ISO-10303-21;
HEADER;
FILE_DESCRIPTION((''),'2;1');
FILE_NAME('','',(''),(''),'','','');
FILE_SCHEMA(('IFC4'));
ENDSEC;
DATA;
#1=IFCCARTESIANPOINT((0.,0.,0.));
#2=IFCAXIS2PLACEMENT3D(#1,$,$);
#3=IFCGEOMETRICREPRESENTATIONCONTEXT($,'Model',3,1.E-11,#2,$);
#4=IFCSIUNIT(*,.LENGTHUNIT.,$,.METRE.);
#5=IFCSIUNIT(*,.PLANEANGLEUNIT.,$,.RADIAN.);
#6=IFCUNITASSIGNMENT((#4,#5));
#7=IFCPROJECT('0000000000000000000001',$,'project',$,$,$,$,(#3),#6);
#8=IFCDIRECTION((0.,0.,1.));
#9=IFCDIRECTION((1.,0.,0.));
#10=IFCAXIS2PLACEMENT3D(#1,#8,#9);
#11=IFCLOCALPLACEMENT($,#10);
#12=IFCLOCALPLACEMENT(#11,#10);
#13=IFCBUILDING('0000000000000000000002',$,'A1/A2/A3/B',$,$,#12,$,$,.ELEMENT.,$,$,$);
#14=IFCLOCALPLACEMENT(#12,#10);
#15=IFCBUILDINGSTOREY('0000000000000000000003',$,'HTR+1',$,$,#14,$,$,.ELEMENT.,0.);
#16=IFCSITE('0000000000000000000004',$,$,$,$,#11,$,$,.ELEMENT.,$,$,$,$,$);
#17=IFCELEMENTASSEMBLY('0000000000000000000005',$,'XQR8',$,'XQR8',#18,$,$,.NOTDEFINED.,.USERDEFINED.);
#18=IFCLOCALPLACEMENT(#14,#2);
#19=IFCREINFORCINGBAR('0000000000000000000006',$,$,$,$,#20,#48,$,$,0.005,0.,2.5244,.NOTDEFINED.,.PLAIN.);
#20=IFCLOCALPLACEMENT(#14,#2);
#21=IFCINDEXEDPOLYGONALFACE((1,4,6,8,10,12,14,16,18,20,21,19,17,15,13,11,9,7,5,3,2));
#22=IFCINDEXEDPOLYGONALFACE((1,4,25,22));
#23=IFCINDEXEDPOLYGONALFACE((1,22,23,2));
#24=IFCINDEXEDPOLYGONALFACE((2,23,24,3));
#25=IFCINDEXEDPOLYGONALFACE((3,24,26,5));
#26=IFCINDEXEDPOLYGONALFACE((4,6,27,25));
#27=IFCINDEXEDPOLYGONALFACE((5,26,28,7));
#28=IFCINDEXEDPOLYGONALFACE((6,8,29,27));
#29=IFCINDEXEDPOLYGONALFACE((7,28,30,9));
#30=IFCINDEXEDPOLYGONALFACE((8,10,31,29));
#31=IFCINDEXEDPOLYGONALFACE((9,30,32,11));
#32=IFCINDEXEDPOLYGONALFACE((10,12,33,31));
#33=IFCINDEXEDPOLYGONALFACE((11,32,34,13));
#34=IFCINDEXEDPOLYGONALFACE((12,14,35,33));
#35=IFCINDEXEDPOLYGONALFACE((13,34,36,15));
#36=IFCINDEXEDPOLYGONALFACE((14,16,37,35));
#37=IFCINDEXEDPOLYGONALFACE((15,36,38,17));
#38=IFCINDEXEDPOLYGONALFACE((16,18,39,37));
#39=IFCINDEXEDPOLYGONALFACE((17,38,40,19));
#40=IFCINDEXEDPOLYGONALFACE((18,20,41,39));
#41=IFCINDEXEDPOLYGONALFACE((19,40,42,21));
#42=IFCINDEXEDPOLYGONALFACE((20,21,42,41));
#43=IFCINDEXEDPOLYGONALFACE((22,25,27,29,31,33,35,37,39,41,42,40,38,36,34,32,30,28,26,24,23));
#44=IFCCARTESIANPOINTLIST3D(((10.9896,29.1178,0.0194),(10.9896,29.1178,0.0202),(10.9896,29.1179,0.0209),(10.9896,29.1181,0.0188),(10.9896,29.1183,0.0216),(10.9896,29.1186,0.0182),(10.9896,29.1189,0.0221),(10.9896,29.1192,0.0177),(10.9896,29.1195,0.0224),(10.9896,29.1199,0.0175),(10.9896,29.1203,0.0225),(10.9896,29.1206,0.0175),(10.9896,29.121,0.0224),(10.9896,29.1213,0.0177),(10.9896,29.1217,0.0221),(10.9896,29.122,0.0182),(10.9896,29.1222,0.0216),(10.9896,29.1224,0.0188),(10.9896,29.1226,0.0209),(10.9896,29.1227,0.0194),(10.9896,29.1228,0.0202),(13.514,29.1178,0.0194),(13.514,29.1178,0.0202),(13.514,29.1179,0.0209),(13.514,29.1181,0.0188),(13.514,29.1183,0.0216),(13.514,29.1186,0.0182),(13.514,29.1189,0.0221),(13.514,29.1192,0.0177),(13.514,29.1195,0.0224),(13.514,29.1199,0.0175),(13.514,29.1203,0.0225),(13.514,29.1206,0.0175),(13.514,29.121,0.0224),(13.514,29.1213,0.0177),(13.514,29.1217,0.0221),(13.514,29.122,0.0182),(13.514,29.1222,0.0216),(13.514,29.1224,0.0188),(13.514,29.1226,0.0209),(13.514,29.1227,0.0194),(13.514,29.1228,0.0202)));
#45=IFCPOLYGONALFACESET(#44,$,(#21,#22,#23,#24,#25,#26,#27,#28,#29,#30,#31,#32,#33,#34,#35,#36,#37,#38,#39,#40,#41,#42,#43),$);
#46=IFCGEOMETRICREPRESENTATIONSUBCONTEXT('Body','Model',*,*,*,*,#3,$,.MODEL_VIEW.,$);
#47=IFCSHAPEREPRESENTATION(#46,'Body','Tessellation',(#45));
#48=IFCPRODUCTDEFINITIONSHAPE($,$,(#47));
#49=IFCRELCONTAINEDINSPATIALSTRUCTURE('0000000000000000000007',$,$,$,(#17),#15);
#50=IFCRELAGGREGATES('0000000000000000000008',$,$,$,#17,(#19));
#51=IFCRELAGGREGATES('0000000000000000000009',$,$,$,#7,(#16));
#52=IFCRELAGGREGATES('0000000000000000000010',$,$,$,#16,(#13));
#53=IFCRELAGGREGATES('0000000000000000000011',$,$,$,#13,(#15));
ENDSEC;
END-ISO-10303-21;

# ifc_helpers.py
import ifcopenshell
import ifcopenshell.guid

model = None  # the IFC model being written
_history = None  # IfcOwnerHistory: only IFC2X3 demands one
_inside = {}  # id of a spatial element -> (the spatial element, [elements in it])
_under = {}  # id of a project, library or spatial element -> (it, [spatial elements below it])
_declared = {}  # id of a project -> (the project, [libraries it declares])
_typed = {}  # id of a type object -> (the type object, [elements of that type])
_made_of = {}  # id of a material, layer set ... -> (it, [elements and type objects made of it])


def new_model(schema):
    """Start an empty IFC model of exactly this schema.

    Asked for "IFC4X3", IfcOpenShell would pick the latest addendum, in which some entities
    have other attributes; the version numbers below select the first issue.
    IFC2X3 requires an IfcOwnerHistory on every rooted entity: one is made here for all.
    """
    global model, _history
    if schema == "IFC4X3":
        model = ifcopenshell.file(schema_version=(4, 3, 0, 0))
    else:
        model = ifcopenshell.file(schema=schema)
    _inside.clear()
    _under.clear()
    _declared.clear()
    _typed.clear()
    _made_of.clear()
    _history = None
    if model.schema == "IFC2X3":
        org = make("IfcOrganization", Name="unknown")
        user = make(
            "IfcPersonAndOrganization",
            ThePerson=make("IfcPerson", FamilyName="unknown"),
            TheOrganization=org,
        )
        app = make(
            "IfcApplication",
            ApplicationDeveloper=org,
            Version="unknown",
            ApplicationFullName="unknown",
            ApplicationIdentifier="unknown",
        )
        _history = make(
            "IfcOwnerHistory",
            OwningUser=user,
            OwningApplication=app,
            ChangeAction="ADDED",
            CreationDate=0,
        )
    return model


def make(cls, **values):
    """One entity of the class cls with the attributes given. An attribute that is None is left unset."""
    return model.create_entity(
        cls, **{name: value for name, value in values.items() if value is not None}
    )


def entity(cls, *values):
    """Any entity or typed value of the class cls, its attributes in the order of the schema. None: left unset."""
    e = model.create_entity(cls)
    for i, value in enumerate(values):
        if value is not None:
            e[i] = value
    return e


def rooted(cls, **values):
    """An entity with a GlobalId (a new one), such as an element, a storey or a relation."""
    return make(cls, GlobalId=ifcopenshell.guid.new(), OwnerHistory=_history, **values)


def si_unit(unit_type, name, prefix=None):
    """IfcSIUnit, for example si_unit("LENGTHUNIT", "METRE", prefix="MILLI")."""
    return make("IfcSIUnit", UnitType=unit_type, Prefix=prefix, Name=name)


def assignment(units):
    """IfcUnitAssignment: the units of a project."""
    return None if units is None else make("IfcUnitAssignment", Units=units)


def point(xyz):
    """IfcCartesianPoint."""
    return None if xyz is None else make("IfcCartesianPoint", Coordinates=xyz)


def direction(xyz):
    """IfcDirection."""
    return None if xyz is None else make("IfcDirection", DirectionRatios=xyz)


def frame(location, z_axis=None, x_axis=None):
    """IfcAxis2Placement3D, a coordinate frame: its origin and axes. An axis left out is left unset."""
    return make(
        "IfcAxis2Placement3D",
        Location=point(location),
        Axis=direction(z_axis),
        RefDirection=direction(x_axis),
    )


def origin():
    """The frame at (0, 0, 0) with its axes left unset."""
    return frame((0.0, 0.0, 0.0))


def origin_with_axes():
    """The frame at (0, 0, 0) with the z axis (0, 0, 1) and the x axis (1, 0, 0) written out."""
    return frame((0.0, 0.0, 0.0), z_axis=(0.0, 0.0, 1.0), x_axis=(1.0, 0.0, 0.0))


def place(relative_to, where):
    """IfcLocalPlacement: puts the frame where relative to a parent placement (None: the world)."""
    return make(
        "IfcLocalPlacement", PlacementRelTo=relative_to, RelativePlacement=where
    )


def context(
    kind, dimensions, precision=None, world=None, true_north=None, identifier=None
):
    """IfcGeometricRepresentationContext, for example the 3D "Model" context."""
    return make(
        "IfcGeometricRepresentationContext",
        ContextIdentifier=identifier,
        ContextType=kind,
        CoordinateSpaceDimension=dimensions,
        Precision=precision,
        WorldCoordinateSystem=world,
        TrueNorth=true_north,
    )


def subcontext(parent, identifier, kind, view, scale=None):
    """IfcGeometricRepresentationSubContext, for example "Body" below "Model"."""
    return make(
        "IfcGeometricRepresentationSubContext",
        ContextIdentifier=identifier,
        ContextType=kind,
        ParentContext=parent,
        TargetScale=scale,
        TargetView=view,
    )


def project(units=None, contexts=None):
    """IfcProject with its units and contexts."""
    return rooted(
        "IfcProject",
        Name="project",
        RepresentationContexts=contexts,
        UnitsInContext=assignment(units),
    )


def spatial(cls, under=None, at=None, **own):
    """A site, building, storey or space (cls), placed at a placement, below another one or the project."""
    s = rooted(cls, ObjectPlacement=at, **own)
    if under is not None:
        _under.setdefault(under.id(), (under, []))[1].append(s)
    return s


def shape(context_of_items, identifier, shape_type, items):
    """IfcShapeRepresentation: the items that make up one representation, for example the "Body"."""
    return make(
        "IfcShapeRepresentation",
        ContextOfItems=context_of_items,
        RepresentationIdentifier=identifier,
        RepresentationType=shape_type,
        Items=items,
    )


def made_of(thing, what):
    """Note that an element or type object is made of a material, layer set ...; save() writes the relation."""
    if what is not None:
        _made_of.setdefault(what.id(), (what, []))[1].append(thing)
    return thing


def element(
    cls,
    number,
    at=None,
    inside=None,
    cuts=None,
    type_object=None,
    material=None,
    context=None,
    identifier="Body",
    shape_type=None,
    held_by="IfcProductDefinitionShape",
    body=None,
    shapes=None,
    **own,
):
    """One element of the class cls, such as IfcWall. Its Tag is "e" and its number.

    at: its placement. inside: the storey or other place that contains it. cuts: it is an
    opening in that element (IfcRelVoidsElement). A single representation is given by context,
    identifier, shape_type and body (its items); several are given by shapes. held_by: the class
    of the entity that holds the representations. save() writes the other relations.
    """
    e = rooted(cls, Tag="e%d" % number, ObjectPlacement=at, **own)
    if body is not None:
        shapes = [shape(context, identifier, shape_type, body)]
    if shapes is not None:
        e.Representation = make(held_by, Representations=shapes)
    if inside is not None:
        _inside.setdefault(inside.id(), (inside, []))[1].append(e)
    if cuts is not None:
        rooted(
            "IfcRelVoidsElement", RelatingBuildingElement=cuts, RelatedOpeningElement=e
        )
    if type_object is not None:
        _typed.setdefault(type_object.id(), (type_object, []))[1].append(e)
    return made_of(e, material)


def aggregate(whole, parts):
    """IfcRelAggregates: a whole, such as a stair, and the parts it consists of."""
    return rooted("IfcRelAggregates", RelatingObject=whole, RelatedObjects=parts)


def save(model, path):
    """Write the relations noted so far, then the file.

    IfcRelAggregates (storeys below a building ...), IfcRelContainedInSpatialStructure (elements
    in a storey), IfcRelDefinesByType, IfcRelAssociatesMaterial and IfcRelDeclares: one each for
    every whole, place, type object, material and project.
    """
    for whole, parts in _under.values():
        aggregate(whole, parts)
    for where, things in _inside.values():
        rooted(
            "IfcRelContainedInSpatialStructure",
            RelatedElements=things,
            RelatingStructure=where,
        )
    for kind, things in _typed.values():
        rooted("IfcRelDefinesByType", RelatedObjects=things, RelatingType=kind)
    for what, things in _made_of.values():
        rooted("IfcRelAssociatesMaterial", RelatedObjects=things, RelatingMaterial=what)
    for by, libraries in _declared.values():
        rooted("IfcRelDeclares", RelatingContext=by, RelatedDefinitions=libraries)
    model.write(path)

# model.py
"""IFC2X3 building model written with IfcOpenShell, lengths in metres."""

from ifc_helpers import new_model, entity, si_unit, origin, origin_with_axes, place, context, subcontext, project, spatial, shape, element, aggregate, save


model = new_model("IFC2X3")

# Units and contexts
model_context = context("Model", 3, precision=1e-11, world=origin())
body_context = subcontext(model_context, "Body", "Model", "MODEL_VIEW")
ifc_project = project(units=[si_unit("LENGTHUNIT", "METRE"), si_unit("PLANEANGLEUNIT", "RADIAN")], contexts=[model_context])

# Site, building, storey
site_placement = place(None, origin_with_axes())
site = spatial("IfcSite", under=ifc_project, at=site_placement, CompositionType="ELEMENT")
building_placement = place(site_placement, origin_with_axes())
building = spatial("IfcBuilding", under=site, at=building_placement, Name="A1/A2/A3/B", CompositionType="ELEMENT")
storey_placement = place(building_placement, origin_with_axes())
storey = spatial("IfcBuildingStorey", under=building, at=storey_placement, Name="HTR+1", CompositionType="ELEMENT", Elevation=0.0)

# Element assembly, reinforcing bar
assembly_1_placement = place(storey_placement, origin_with_axes())
assembly_1 = element("IfcElementAssembly", 1, at=assembly_1_placement, inside=storey, Name="XQR8", ObjectType="XQR8", AssemblyPlace="NOTDEFINED", PredefinedType="USERDEFINED")
reinforcing_bar_1_placement = place(assembly_1_placement, origin_with_axes())
reinforcing_bar_1 = element("IfcReinforcingBar", 2, at=reinforcing_bar_1_placement, BarLength=2.5244, BarRole="NOTDEFINED", BarSurface="PLAIN", CrossSectionArea=0.0, NominalDiameter=0.005, shapes=[
    shape(body_context, "Body", "AdvancedSweptSolid", [entity("IfcSweptDiskSolid", entity("IfcPolyline", [entity("IfcCartesianPoint", [10.9896, 29.1203, 0.02]), entity("IfcCartesianPoint", [13.514, 29.1203, 0.02])]), 0.0025, None, 0.0, 2.5244)]),
    shape(body_context, "Body", "AdvancedSweptSolid", [entity("IfcSweptDiskSolid", entity("IfcPolyline", [entity("IfcCartesianPoint", [10.9896, 29.1203, 0.02]), entity("IfcCartesianPoint", [13.514, 29.1203, 0.02])]), 0.0025, None, 0.0, 2.5244)]),
])
aggregate(assembly_1, [reinforcing_bar_1])

save(model, "model.ifc")
